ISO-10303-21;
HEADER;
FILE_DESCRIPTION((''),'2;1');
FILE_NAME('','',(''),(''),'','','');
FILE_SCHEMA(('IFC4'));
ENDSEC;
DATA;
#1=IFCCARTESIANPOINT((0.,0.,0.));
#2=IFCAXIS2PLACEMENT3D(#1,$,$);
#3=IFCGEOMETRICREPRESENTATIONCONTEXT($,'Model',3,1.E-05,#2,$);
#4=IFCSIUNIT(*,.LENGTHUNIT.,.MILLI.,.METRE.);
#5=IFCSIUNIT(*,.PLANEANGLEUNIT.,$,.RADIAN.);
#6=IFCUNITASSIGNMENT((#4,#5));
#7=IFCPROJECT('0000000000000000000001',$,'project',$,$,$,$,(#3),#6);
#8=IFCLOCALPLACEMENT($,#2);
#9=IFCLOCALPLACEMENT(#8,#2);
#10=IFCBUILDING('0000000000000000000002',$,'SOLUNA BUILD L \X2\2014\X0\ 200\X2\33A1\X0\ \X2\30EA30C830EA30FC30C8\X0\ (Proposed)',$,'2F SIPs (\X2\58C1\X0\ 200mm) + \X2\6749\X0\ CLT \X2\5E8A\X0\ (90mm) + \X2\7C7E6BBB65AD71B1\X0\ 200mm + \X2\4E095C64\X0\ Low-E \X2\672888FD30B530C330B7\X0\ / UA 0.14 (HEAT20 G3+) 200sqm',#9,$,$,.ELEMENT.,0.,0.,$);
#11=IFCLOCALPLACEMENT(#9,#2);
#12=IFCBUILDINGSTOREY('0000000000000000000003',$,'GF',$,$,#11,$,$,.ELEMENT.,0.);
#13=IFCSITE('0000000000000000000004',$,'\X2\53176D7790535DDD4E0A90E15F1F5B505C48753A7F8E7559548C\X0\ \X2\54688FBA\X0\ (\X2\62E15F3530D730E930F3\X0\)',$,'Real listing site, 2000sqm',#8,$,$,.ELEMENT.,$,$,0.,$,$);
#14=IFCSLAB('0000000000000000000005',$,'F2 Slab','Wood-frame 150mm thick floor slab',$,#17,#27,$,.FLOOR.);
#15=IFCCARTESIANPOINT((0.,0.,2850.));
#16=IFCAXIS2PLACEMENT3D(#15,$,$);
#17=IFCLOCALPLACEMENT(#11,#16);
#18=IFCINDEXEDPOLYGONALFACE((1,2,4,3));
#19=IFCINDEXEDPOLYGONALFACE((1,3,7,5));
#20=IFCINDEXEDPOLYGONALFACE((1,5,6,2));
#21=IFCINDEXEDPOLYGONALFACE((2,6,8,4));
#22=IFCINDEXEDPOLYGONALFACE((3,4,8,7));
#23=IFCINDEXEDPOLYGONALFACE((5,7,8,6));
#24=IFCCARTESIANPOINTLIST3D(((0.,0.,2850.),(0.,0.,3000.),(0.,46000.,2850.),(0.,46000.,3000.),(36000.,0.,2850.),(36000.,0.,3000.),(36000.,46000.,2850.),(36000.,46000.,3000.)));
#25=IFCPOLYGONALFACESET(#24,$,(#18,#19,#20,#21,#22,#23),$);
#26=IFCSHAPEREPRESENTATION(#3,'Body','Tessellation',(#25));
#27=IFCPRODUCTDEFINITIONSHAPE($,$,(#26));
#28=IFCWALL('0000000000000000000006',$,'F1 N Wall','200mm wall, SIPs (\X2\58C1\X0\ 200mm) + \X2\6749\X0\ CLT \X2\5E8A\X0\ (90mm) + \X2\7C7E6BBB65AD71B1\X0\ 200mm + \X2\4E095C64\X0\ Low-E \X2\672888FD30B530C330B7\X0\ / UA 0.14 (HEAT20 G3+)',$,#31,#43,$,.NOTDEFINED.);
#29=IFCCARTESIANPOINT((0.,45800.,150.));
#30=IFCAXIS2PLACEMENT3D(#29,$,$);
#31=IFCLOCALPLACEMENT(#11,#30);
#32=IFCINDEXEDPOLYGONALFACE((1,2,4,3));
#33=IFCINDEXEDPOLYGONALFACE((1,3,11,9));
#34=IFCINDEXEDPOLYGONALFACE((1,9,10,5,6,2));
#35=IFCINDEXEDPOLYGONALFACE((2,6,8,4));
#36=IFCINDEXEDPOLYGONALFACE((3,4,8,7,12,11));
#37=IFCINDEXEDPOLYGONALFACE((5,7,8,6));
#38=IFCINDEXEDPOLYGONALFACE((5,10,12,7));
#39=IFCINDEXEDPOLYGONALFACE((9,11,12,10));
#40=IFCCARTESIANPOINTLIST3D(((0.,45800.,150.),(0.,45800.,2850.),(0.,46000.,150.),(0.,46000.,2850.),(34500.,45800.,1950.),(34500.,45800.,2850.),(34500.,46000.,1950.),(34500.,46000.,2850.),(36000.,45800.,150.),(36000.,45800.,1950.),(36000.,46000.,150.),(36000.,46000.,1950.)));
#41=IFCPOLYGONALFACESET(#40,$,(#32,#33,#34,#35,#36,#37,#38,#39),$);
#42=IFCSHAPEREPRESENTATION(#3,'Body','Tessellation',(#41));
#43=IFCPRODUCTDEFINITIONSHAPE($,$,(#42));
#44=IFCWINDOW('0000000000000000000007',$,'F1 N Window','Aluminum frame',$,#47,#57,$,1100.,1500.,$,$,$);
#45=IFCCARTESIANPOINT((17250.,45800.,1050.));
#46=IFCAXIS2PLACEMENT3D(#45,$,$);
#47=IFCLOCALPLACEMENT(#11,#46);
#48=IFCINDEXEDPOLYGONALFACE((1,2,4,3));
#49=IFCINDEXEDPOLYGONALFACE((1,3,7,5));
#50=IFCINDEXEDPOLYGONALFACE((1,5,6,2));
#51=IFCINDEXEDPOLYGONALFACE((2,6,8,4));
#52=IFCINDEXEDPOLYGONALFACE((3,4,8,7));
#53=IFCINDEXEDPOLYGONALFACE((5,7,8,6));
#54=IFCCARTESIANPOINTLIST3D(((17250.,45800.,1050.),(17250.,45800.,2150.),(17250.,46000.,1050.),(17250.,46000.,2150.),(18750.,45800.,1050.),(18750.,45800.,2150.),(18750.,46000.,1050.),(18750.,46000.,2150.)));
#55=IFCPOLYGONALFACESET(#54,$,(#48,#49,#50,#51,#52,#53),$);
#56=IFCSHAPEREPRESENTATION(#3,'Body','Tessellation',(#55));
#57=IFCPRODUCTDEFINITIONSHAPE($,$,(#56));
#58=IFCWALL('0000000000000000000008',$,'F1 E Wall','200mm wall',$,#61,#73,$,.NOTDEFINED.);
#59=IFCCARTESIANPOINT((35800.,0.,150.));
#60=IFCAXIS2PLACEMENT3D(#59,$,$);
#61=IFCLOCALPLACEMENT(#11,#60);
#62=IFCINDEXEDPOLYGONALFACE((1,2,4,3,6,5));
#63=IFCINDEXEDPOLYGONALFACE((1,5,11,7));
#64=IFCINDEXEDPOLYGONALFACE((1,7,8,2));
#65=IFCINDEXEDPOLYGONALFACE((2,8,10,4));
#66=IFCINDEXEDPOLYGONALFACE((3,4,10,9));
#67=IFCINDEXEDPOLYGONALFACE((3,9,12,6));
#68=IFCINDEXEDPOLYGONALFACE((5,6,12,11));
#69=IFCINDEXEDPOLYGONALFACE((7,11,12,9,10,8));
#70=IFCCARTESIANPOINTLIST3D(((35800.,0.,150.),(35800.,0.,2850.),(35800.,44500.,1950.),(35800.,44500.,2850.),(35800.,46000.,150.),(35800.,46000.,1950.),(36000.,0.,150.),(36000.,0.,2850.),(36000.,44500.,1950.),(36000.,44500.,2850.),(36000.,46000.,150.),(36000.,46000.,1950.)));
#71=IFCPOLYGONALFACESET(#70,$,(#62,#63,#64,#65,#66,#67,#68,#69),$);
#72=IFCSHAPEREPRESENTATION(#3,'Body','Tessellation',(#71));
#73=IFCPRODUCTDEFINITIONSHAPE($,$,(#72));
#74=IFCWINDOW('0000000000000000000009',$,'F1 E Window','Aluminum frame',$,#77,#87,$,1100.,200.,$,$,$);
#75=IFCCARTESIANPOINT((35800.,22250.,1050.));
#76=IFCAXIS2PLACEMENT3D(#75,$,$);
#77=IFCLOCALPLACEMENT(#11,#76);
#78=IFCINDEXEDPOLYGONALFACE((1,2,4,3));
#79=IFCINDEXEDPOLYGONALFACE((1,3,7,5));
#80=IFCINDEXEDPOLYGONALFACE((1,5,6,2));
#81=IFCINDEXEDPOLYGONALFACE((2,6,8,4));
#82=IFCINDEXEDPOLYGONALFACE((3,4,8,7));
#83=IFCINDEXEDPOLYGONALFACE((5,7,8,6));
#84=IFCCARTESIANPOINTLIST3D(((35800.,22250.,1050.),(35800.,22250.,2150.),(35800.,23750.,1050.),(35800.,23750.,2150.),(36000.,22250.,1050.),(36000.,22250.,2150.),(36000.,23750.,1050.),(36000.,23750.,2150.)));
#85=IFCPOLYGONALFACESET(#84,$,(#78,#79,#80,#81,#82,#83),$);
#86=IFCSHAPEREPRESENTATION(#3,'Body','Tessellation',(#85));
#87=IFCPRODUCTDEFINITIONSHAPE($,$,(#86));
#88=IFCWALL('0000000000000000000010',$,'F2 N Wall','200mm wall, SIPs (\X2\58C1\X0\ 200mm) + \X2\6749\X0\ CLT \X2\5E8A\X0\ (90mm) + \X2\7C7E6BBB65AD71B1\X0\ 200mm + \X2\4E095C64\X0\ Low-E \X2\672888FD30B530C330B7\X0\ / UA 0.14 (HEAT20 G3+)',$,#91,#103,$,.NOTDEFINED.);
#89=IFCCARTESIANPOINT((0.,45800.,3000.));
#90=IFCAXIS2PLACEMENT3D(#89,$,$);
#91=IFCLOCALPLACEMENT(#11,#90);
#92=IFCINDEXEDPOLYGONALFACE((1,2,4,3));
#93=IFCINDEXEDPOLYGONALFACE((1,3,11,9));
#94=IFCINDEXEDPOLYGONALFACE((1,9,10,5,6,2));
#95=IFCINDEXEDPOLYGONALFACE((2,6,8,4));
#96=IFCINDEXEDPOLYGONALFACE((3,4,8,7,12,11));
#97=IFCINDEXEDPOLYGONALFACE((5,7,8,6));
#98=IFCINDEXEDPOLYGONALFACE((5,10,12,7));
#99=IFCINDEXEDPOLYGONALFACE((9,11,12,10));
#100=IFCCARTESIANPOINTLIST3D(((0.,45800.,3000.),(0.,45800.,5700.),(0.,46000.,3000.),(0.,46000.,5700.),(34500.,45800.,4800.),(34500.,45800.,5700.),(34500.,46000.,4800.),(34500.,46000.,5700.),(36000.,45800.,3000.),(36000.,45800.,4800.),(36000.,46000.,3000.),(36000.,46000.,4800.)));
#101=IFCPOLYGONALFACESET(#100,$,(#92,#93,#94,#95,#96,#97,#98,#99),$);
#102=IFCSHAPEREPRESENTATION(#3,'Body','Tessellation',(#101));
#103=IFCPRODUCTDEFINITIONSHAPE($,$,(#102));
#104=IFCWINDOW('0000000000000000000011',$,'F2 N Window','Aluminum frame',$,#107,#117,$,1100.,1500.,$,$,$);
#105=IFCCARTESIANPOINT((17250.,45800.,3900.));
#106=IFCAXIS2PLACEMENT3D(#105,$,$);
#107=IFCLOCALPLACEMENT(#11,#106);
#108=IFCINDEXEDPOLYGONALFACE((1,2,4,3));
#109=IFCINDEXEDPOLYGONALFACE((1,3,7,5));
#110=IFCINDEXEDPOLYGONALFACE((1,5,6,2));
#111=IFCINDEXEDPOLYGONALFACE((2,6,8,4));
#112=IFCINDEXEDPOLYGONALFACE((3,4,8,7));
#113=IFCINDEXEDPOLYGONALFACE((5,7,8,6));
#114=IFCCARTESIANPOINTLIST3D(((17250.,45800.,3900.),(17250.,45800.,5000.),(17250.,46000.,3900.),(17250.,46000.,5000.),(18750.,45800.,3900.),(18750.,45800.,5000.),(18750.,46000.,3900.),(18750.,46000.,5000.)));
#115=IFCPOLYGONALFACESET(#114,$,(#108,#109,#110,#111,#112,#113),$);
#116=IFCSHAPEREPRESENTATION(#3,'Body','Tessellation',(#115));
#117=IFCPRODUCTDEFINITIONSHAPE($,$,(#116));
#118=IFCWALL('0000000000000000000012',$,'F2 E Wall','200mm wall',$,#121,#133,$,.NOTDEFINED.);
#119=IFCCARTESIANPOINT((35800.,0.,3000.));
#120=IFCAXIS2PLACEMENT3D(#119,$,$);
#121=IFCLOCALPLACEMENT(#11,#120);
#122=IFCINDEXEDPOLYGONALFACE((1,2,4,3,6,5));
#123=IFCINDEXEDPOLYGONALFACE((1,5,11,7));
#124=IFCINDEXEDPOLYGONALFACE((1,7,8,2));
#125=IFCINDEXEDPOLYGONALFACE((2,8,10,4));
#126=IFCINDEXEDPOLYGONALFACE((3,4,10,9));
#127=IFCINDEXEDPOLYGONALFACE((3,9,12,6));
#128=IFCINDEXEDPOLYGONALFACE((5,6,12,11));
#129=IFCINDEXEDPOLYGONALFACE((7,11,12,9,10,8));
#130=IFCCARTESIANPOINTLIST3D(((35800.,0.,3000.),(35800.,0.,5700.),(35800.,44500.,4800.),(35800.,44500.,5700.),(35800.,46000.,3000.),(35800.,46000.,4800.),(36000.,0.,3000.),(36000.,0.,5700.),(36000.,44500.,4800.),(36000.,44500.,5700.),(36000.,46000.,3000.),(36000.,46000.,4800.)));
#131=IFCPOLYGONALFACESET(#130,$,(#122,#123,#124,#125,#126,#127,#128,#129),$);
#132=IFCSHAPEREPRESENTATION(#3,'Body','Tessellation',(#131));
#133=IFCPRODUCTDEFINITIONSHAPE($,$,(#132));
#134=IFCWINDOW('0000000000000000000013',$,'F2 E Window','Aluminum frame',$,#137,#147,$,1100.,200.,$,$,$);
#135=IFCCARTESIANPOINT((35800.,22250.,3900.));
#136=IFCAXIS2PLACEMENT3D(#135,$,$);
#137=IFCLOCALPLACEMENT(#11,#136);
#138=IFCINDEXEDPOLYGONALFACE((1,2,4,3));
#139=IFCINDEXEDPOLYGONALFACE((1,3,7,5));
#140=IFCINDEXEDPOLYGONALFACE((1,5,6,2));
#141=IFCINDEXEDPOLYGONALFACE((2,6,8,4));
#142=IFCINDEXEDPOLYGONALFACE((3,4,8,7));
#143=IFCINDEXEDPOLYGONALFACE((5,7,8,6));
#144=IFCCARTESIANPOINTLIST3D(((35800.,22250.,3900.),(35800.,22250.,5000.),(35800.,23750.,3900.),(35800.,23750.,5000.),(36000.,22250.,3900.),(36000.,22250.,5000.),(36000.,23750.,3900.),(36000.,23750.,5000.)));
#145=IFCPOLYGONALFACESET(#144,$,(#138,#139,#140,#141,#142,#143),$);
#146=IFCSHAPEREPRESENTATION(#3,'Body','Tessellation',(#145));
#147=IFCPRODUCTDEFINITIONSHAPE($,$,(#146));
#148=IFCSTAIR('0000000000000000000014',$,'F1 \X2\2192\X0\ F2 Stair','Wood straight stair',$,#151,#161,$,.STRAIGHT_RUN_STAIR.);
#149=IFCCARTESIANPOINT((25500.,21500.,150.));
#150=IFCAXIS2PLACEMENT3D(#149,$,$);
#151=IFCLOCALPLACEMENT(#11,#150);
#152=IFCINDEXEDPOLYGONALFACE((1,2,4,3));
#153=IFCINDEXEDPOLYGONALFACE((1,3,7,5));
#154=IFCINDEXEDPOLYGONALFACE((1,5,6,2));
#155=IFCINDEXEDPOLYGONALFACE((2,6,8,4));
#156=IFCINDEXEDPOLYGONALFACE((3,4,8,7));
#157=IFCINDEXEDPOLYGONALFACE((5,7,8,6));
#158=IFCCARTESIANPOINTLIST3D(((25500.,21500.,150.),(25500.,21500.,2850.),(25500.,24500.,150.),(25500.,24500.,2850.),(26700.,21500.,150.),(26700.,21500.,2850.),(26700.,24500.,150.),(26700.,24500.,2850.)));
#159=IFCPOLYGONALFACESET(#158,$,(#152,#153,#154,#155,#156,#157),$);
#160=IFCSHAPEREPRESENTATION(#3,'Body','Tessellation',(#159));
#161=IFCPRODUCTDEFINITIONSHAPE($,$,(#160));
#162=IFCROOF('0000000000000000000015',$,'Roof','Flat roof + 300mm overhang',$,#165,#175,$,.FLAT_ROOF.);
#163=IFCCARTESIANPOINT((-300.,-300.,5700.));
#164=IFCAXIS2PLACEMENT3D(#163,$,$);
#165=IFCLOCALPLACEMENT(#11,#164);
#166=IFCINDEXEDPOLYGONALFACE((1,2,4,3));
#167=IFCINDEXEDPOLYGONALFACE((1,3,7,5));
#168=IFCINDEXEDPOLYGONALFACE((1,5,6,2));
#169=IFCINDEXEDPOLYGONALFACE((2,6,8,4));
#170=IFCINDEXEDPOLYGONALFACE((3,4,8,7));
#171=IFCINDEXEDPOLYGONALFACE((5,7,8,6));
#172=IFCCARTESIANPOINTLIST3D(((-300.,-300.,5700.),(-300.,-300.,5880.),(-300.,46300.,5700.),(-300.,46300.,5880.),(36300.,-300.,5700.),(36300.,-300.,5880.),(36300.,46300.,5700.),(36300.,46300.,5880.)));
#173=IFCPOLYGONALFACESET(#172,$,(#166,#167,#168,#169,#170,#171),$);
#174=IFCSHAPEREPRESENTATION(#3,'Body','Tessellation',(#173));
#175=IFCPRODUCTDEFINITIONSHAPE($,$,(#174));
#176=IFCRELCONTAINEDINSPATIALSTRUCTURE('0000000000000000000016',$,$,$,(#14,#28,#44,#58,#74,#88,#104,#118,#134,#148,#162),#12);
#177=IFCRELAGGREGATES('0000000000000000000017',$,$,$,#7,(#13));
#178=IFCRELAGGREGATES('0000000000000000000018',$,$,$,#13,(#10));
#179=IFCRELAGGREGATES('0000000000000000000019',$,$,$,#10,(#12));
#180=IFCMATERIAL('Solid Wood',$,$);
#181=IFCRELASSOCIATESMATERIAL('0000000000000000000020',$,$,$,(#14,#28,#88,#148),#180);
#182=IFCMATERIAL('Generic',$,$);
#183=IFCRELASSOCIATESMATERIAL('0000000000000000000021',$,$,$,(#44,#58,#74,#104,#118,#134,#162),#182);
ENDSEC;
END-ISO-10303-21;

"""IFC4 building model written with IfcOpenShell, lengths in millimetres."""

from ifc_helpers import new_model, si_unit, frame, frame_2d, origin, place, context, project, spatial, rectangle, extrude, material, element, fill, save


model = new_model("IFC4")

# Units and contexts
model_context = context("Model", 3, precision=1e-05, world=origin())
ifc_project = project(units=[si_unit("LENGTHUNIT", "METRE", prefix="MILLI"), si_unit("PLANEANGLEUNIT", "RADIAN")], contexts=[model_context])

# Site, building, storey
site_placement = place(None, origin())
site = spatial("IfcSite", under=ifc_project, at=site_placement, Name="北海道川上郡弟子屈町美留和 周辺 (拡張プラン)", ObjectType="Real listing site, 2000sqm", CompositionType="ELEMENT", RefElevation=0.0)
building_placement = place(site_placement, origin())
building = spatial("IfcBuilding", under=site, at=building_placement, Name="SOLUNA BUILD L — 200㎡ リトリート (Proposed)", ObjectType="2F SIPs (壁 200mm) + 杉 CLT 床 (90mm) + 籾殻断熱 200mm + 三層 Low-E 木製サッシ / UA 0.14 (HEAT20 G3+) 200sqm", CompositionType="ELEMENT", ElevationOfRefHeight=0.0, ElevationOfTerrain=0.0)
storey_placement = place(building_placement, origin())
storey = spatial("IfcBuildingStorey", under=building, at=storey_placement, Name="GF", CompositionType="ELEMENT", Elevation=0.0)

# Slab
ifc_material_1 = material(Name="Solid Wood")
slab_1_placement = place(storey_placement, frame((0.0, 0.0, 2850.0)))
element("IfcSlab", 1, at=slab_1_placement, inside=storey, material=ifc_material_1, Name="F2 Slab", Description="Wood-frame 150mm thick floor slab", PredefinedType="FLOOR", context=model_context, shape_type="SweptSolid", body=[
    extrude(rectangle(XDim=36000.0, YDim=46000.0, at=frame_2d((18000.0, 23000.0))), frame((0.0, 0.0, 2850.0)), (0.0, 0.0, 1.0), 150.0),
])

# Wall, opening, window
wall_1_placement = place(storey_placement, frame((0.0, 45800.0, 150.0)))
wall_1 = element("IfcWall", 2, at=wall_1_placement, inside=storey, material=ifc_material_1, Name="F1 N Wall", Description="200mm wall, SIPs (壁 200mm) + 杉 CLT 床 (90mm) + 籾殻断熱 200mm + 三層 Low-E 木製サッシ / UA 0.14 (HEAT20 G3+)", PredefinedType="NOTDEFINED", context=model_context, shape_type="SweptSolid", body=[
    extrude(rectangle(XDim=36000.0, YDim=200.0, at=frame_2d((18000.0, 100.0))), frame((0.0, 45800.0, 150.0)), (0.0, 0.0, 1.0), 2700.0),
])
opening_1_placement = place(storey_placement, frame((17250.0, 45800.0, 1050.0)))
opening_1 = element("IfcOpeningElement", 3, at=opening_1_placement, cuts=wall_1, PredefinedType="NOTDEFINED", context=model_context, shape_type="SweptSolid", body=[
    extrude(rectangle(XDim=1500.0, YDim=200.0, at=frame_2d((750.0, 100.0))), frame((17250.0, 45800.0, 1050.0)), (0.0, 0.0, 1.0), 1100.0),
])
ifc_material_2 = material(Name="Generic")
window_1_placement = place(storey_placement, frame((17250.0, 45800.0, 1050.0)))
window_1 = element("IfcWindow", 4, at=window_1_placement, inside=storey, material=ifc_material_2, Name="F1 N Window", Description="Aluminum frame", OverallHeight=1100.0, OverallWidth=1500.0, context=model_context, shape_type="SweptSolid", body=[
    extrude(rectangle(XDim=1500.0, YDim=200.0, at=frame_2d((750.0, 100.0))), frame((17250.0, 45800.0, 1050.0)), (0.0, 0.0, 1.0), 1100.0),
])
fill(opening_1, window_1)

# Walls, openings, windows
wall_2_placement = place(storey_placement, frame((35800.0, 0.0, 150.0)))
wall_2 = element("IfcWall", 5, at=wall_2_placement, inside=storey, material=ifc_material_2, Name="F1 E Wall", Description="200mm wall", PredefinedType="NOTDEFINED", context=model_context, shape_type="SweptSolid", body=[
    extrude(rectangle(XDim=200.0, YDim=46000.0, at=frame_2d((100.0, 23000.0))), frame((35800.0, 0.0, 150.0)), (0.0, 0.0, 1.0), 2700.0),
])
opening_2_placement = place(storey_placement, frame((35800.0, 22250.0, 1050.0)))
opening_2 = element("IfcOpeningElement", 6, at=opening_2_placement, cuts=wall_2, PredefinedType="NOTDEFINED", context=model_context, shape_type="SweptSolid", body=[
    extrude(rectangle(XDim=200.0, YDim=1500.0, at=frame_2d((100.0, 750.0))), frame((35800.0, 22250.0, 1050.0)), (0.0, 0.0, 1.0), 1100.0),
])
window_2_placement = place(storey_placement, frame((35800.0, 22250.0, 1050.0)))
window_2 = element("IfcWindow", 7, at=window_2_placement, inside=storey, material=ifc_material_2, Name="F1 E Window", Description="Aluminum frame", OverallHeight=1100.0, OverallWidth=200.0, context=model_context, shape_type="SweptSolid", body=[
    extrude(rectangle(XDim=200.0, YDim=1500.0, at=frame_2d((100.0, 750.0))), frame((35800.0, 22250.0, 1050.0)), (0.0, 0.0, 1.0), 1100.0),
])
fill(opening_2, window_2)
wall_3_placement = place(storey_placement, frame((0.0, 45800.0, 3000.0)))
wall_3 = element("IfcWall", 8, at=wall_3_placement, inside=storey, material=ifc_material_1, Name="F2 N Wall", Description="200mm wall, SIPs (壁 200mm) + 杉 CLT 床 (90mm) + 籾殻断熱 200mm + 三層 Low-E 木製サッシ / UA 0.14 (HEAT20 G3+)", PredefinedType="NOTDEFINED", context=model_context, shape_type="SweptSolid", body=[
    extrude(rectangle(XDim=36000.0, YDim=200.0, at=frame_2d((18000.0, 100.0))), frame((0.0, 45800.0, 3000.0)), (0.0, 0.0, 1.0), 2700.0),
])
opening_3_placement = place(storey_placement, frame((17250.0, 45800.0, 3900.0)))
opening_3 = element("IfcOpeningElement", 9, at=opening_3_placement, cuts=wall_3, PredefinedType="NOTDEFINED", context=model_context, shape_type="SweptSolid", body=[
    extrude(rectangle(XDim=1500.0, YDim=200.0, at=frame_2d((750.0, 100.0))), frame((17250.0, 45800.0, 3900.0)), (0.0, 0.0, 1.0), 1100.0),
])
window_3_placement = place(storey_placement, frame((17250.0, 45800.0, 3900.0)))
window_3 = element("IfcWindow", 10, at=window_3_placement, inside=storey, material=ifc_material_2, Name="F2 N Window", Description="Aluminum frame", OverallHeight=1100.0, OverallWidth=1500.0, context=model_context, shape_type="SweptSolid", body=[
    extrude(rectangle(XDim=1500.0, YDim=200.0, at=frame_2d((750.0, 100.0))), frame((17250.0, 45800.0, 3900.0)), (0.0, 0.0, 1.0), 1100.0),
])
fill(opening_3, window_3)
wall_4_placement = place(storey_placement, frame((35800.0, 0.0, 3000.0)))
wall_4 = element("IfcWall", 11, at=wall_4_placement, inside=storey, material=ifc_material_2, Name="F2 E Wall", Description="200mm wall", PredefinedType="NOTDEFINED", context=model_context, shape_type="SweptSolid", body=[
    extrude(rectangle(XDim=200.0, YDim=46000.0, at=frame_2d((100.0, 23000.0))), frame((35800.0, 0.0, 3000.0)), (0.0, 0.0, 1.0), 2700.0),
])
opening_4_placement = place(storey_placement, frame((35800.0, 22250.0, 3900.0)))
opening_4 = element("IfcOpeningElement", 12, at=opening_4_placement, cuts=wall_4, PredefinedType="NOTDEFINED", context=model_context, shape_type="SweptSolid", body=[
    extrude(rectangle(XDim=200.0, YDim=1500.0, at=frame_2d((100.0, 750.0))), frame((35800.0, 22250.0, 3900.0)), (0.0, 0.0, 1.0), 1100.0),
])
window_4_placement = place(storey_placement, frame((35800.0, 22250.0, 3900.0)))
window_4 = element("IfcWindow", 13, at=window_4_placement, inside=storey, material=ifc_material_2, Name="F2 E Window", Description="Aluminum frame", OverallHeight=1100.0, OverallWidth=200.0, context=model_context, shape_type="SweptSolid", body=[
    extrude(rectangle(XDim=200.0, YDim=1500.0, at=frame_2d((100.0, 750.0))), frame((35800.0, 22250.0, 3900.0)), (0.0, 0.0, 1.0), 1100.0),
])
fill(opening_4, window_4)

# Stair
stair_placement = place(storey_placement, frame((25500.0, 21500.0, 150.0)))
element("IfcStair", 14, at=stair_placement, inside=storey, material=ifc_material_1, Name="F1 → F2 Stair", Description="Wood straight stair", PredefinedType="STRAIGHT_RUN_STAIR", context=model_context, shape_type="SweptSolid", body=[
    extrude(rectangle(XDim=1200.0, YDim=3000.0, at=frame_2d((600.0, 1500.0))), frame((25500.0, 21500.0, 150.0)), (0.0, 0.0, 1.0), 2700.0),
])

# Roof
roof_placement = place(storey_placement, frame((-300.0, -300.0, 5700.0)))
element("IfcRoof", 15, at=roof_placement, inside=storey, material=ifc_material_2, Name="Roof", Description="Flat roof + 300mm overhang", PredefinedType="FLAT_ROOF", context=model_context, shape_type="SweptSolid", body=[
    extrude(rectangle(XDim=36600.0, YDim=46600.0, at=frame_2d((18300.0, 23300.0))), frame((-300.0, -300.0, 5700.0)), (0.0, 0.0, 1.0), 180.0),
])

save(model, "model.ifc")
